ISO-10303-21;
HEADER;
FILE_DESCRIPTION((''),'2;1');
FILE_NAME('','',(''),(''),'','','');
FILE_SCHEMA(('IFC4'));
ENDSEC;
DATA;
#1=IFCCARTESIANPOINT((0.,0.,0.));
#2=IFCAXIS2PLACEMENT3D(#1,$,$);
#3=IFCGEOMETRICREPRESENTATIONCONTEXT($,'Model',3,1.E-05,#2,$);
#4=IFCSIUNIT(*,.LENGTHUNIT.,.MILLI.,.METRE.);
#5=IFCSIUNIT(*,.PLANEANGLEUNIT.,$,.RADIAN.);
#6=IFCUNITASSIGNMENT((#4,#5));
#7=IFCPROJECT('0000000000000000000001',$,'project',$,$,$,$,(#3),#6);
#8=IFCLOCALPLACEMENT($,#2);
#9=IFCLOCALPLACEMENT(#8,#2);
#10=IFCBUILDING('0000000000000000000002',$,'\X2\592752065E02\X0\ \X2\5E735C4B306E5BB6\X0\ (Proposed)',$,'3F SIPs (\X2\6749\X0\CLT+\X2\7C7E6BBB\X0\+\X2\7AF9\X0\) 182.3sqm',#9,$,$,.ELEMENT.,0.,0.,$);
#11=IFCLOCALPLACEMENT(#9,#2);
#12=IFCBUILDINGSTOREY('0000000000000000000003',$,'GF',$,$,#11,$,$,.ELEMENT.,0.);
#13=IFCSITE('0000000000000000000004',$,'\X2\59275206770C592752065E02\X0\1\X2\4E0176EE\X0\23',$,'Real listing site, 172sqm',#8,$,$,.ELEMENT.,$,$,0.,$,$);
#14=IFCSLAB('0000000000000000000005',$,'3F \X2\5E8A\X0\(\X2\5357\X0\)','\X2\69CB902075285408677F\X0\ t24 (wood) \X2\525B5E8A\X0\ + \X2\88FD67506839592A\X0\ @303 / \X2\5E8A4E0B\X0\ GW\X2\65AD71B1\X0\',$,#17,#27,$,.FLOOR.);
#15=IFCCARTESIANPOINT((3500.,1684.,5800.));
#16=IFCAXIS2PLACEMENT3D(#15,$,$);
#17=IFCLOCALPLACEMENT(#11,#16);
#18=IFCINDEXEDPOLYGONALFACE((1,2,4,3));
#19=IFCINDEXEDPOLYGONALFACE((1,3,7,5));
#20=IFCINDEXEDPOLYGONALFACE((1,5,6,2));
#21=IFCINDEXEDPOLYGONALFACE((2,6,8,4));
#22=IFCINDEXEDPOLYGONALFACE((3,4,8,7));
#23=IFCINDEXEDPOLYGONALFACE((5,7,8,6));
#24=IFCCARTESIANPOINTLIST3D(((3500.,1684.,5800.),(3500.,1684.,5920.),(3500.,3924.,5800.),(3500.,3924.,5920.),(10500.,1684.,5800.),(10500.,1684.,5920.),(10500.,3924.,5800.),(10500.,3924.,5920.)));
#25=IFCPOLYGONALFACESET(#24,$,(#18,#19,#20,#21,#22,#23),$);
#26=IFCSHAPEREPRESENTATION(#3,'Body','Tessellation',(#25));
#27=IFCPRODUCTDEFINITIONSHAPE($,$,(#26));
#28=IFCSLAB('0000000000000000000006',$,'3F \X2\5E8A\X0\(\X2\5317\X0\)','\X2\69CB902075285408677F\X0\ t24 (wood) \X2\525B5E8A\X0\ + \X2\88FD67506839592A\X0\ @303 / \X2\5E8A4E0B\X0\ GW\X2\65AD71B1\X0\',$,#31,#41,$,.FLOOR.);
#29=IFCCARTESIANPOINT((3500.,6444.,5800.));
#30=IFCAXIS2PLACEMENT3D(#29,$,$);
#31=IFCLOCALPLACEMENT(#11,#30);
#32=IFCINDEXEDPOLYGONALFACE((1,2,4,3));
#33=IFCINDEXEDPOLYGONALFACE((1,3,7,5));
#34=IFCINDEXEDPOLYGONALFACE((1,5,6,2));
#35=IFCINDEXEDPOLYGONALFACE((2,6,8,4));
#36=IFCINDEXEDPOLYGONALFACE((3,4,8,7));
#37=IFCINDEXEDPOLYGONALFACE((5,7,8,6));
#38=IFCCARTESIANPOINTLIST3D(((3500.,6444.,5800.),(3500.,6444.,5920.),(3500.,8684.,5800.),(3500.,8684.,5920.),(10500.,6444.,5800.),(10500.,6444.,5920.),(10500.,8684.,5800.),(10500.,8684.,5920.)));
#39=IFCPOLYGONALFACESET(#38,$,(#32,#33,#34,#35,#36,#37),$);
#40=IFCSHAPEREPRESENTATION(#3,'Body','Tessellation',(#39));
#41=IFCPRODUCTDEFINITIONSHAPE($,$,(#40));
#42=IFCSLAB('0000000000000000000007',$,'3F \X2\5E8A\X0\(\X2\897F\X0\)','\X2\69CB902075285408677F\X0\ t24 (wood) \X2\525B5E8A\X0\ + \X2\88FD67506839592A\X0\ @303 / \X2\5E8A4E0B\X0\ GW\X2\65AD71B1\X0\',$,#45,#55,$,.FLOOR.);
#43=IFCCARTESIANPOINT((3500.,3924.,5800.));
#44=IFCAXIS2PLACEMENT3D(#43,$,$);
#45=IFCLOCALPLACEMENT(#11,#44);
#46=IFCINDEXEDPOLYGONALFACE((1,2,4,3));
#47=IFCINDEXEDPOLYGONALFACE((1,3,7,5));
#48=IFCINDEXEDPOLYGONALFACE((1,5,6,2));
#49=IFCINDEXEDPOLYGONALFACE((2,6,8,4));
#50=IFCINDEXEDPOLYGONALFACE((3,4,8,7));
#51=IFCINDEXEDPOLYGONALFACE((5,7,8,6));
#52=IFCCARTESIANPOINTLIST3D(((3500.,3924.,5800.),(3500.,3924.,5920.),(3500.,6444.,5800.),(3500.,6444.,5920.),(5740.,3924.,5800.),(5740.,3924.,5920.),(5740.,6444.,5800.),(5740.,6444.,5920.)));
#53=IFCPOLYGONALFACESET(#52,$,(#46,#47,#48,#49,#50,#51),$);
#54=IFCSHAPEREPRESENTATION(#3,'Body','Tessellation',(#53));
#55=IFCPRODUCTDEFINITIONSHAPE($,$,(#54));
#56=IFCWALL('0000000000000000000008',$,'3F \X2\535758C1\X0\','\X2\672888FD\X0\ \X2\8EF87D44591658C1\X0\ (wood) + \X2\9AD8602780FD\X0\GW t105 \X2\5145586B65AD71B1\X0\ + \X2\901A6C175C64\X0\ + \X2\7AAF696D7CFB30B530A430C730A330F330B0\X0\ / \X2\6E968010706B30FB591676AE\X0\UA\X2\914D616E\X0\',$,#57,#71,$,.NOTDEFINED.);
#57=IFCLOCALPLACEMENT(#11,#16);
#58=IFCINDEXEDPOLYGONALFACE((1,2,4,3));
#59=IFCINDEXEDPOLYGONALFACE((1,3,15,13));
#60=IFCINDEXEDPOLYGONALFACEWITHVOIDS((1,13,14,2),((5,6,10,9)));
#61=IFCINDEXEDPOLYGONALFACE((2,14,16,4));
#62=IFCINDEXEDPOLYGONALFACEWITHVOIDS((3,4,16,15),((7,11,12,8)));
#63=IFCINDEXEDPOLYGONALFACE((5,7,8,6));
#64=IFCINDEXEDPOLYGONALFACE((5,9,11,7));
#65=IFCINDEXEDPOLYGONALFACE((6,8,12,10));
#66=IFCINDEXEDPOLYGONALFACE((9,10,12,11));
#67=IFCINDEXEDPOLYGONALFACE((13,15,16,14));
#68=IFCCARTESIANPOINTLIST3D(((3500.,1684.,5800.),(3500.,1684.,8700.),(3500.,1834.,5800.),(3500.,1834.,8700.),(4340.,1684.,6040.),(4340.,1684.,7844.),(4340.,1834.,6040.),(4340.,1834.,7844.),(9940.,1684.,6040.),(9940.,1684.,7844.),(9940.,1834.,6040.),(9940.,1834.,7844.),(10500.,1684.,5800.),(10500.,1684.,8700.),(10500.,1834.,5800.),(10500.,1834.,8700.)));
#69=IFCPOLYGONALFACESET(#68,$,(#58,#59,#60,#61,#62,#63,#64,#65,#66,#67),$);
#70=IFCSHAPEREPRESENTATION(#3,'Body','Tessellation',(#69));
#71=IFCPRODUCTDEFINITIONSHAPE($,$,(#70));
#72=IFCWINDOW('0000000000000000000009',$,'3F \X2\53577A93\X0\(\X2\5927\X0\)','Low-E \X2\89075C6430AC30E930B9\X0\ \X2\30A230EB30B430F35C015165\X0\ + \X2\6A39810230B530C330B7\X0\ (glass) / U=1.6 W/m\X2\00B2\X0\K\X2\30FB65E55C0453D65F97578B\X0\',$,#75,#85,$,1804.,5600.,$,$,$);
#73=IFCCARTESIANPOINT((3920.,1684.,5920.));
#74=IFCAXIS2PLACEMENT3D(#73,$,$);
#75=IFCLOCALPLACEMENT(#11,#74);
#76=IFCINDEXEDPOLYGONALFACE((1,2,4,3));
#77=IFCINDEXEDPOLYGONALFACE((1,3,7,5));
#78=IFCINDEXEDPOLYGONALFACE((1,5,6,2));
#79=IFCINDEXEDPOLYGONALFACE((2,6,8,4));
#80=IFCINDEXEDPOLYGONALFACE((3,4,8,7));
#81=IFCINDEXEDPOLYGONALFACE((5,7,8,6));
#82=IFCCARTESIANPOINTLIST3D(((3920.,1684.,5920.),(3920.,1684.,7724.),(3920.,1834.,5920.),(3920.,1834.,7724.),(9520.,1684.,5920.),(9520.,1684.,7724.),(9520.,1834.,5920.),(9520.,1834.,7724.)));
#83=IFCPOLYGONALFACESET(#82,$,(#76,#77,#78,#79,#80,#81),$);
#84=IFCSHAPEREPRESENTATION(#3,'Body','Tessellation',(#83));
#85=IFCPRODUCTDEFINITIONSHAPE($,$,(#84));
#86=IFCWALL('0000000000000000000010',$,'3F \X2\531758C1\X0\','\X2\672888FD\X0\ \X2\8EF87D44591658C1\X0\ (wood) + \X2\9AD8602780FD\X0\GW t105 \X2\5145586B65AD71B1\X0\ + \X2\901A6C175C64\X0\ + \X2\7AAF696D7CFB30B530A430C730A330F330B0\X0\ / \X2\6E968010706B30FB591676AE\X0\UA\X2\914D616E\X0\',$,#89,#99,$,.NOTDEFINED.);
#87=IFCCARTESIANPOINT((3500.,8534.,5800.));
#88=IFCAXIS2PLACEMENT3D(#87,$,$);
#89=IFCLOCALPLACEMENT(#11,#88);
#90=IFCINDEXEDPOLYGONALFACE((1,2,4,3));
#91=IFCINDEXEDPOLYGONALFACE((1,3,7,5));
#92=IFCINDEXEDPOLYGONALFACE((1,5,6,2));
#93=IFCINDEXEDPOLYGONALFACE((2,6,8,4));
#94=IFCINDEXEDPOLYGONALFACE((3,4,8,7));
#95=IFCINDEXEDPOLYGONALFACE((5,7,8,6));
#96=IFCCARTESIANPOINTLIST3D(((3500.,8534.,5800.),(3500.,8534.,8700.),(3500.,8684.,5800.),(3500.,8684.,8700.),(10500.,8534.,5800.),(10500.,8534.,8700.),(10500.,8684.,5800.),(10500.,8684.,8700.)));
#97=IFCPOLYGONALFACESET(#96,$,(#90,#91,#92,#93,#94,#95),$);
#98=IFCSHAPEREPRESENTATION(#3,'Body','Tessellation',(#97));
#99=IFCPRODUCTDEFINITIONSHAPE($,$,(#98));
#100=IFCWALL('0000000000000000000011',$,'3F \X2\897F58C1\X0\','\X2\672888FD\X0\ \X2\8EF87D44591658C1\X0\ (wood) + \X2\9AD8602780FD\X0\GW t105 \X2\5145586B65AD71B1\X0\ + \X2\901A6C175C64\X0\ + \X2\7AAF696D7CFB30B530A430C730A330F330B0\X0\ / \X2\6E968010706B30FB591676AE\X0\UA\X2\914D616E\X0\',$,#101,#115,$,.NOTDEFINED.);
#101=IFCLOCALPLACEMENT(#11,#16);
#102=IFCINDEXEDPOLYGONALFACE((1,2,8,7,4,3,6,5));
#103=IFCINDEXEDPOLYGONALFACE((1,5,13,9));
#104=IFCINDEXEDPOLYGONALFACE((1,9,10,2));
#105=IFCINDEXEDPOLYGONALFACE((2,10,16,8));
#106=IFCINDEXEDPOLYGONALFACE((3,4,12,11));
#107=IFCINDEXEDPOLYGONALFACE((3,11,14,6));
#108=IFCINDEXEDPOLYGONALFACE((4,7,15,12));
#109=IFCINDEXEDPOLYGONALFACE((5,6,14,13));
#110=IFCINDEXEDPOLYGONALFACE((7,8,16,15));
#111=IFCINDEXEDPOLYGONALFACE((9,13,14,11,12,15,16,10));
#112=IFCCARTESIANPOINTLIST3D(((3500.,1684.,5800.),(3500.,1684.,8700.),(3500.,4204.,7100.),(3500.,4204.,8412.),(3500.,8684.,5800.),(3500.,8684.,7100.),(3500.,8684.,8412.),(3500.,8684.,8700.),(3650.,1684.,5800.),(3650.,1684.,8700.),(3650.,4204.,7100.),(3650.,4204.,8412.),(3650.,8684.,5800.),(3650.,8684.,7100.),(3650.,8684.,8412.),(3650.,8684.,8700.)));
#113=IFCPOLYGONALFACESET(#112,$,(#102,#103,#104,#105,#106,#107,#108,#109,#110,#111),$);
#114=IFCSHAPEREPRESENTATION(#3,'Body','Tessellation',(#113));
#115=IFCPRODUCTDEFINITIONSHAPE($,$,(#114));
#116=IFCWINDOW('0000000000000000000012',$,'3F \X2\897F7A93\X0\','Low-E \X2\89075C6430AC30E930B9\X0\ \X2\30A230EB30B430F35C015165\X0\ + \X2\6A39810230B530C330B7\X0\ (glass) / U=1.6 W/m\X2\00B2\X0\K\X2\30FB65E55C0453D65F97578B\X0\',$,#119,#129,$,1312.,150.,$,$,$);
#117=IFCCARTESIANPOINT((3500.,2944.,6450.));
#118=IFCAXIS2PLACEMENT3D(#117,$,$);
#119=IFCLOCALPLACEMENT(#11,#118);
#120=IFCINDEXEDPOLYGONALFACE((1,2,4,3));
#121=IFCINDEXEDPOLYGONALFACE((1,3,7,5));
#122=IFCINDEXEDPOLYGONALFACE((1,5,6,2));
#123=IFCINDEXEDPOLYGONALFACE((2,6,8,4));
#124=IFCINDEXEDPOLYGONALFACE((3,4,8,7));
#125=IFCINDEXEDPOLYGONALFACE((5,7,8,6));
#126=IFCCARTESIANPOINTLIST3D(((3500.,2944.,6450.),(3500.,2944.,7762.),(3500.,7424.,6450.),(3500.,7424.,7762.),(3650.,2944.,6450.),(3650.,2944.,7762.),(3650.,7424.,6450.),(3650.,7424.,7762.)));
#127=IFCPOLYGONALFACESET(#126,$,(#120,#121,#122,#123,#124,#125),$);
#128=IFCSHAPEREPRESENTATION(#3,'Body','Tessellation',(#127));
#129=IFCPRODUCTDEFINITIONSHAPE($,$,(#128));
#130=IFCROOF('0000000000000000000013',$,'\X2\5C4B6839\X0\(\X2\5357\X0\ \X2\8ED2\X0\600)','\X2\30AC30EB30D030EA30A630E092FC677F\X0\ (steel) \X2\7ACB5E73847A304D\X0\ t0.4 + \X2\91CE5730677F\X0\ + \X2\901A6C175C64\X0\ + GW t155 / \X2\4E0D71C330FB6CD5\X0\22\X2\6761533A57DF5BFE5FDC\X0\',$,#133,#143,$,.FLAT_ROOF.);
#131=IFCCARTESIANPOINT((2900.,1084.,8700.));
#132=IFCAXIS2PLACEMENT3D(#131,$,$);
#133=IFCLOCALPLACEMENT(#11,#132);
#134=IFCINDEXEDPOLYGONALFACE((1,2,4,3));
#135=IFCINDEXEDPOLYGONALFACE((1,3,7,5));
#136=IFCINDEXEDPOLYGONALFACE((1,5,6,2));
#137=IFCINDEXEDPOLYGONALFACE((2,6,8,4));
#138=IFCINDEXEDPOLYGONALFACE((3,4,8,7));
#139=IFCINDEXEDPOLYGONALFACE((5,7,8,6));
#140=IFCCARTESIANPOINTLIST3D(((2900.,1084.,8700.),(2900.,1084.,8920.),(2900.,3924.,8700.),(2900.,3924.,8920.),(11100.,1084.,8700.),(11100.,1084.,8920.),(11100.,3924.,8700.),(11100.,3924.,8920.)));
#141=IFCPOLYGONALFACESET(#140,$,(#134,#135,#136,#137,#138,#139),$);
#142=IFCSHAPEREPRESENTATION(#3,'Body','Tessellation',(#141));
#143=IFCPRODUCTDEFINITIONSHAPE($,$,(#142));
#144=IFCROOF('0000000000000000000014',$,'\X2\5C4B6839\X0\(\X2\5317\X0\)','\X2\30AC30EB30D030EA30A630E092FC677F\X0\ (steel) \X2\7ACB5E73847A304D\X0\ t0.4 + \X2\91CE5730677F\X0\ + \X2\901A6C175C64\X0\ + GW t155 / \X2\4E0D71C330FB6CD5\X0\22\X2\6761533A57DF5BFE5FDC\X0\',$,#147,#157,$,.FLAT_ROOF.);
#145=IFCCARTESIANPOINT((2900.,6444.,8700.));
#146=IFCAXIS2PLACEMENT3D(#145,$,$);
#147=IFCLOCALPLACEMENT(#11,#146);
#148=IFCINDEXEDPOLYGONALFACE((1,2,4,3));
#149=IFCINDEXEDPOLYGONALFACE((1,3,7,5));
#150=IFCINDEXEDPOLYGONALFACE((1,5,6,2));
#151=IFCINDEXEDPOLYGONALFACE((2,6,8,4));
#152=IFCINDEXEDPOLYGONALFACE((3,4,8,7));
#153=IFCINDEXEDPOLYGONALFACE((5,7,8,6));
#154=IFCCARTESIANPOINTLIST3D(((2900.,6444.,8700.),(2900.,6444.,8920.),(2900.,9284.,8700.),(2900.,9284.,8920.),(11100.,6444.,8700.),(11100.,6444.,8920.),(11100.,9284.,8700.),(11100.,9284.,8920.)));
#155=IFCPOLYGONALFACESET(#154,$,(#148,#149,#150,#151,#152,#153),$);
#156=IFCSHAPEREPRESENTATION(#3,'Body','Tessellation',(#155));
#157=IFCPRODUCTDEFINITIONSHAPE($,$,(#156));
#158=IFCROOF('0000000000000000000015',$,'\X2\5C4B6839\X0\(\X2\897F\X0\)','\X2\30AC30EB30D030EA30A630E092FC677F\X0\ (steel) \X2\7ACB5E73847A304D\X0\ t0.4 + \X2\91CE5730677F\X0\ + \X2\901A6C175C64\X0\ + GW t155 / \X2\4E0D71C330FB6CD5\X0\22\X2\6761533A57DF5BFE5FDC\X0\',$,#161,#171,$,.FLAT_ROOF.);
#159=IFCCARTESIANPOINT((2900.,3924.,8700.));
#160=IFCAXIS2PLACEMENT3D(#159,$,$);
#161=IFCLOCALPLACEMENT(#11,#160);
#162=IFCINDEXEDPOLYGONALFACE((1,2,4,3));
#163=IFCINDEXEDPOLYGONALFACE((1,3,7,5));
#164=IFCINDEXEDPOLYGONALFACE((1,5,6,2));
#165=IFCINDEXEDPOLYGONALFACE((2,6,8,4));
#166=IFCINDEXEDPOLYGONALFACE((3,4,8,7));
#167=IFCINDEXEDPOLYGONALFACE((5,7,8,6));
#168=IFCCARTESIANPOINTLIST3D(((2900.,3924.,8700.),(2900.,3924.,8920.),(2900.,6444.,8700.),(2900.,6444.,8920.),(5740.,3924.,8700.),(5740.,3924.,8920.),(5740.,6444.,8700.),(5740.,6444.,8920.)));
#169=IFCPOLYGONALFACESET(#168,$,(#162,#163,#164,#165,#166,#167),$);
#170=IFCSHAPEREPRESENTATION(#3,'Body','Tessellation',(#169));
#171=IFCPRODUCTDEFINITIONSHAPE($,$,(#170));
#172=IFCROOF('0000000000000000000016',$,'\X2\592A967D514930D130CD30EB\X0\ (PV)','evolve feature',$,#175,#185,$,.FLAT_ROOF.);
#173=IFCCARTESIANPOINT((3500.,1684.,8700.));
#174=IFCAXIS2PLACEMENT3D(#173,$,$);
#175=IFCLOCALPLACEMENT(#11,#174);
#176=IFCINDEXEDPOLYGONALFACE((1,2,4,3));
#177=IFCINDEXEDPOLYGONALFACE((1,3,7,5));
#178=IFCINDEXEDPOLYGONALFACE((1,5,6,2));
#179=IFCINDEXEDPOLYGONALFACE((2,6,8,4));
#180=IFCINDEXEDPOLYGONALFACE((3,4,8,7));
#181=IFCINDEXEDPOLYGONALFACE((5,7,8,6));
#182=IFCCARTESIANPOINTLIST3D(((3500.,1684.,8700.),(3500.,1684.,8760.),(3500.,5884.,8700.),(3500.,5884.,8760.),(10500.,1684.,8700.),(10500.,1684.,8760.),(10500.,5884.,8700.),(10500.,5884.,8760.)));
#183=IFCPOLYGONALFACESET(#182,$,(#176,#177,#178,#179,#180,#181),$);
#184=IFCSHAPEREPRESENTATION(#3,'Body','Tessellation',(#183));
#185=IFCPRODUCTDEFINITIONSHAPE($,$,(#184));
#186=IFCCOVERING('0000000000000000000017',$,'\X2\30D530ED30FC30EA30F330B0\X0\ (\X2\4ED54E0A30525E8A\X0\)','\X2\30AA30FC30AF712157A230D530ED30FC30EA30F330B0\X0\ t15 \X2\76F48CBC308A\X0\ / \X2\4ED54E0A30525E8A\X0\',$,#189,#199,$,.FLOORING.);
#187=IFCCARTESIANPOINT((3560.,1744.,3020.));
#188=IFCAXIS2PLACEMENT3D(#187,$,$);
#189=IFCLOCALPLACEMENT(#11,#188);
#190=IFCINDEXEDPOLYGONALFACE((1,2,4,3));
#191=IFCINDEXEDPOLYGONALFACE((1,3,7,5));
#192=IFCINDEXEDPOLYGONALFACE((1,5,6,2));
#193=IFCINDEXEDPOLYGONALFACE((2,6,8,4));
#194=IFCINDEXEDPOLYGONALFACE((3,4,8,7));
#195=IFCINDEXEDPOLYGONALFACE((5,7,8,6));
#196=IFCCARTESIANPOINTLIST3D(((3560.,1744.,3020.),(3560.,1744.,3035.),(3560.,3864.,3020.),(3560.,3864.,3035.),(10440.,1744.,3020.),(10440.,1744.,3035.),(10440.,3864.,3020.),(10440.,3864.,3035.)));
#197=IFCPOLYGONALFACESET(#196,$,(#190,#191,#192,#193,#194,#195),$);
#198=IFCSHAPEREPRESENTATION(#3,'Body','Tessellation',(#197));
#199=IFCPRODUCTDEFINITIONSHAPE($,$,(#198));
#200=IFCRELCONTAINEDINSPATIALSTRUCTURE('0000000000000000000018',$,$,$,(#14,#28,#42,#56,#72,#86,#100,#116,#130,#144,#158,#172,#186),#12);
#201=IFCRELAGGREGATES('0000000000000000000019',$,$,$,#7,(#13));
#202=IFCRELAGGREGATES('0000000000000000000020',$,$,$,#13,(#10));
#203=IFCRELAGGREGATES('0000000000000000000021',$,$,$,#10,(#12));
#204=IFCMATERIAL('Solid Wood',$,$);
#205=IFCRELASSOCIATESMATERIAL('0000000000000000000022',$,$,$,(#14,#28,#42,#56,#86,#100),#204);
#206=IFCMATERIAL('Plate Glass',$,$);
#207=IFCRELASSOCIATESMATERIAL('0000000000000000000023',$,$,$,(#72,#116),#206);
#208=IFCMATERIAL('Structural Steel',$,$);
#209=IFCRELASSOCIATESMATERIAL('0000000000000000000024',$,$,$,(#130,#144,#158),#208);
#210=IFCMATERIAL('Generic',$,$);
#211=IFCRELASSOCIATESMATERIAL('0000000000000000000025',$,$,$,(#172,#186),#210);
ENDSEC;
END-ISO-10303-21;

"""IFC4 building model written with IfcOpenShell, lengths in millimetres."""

from ifc_helpers import new_model, si_unit, frame, frame_2d, origin, place, context, project, spatial, rectangle, extrude, material, element, fill, save


model = new_model("IFC4")

# Units and contexts
model_context = context("Model", 3, precision=1e-05, world=origin())
ifc_project = project(units=[si_unit("LENGTHUNIT", "METRE", prefix="MILLI"), si_unit("PLANEANGLEUNIT", "RADIAN")], contexts=[model_context])

# Site, building, storey
site_placement = place(None, origin())
site = spatial("IfcSite", under=ifc_project, at=site_placement, Name="大分県大分市1丁目23", ObjectType="Real listing site, 172sqm", CompositionType="ELEMENT", RefElevation=0.0)
building_placement = place(site_placement, origin())
building = spatial("IfcBuilding", under=site, at=building_placement, Name="大分市 平屋の家 (Proposed)", ObjectType="3F SIPs (杉CLT+籾殻+竹) 182.3sqm", CompositionType="ELEMENT", ElevationOfRefHeight=0.0, ElevationOfTerrain=0.0)
storey_placement = place(building_placement, origin())
storey = spatial("IfcBuildingStorey", under=building, at=storey_placement, Name="GF", CompositionType="ELEMENT", Elevation=0.0)

# Slabs
ifc_material_1 = material(Name="Solid Wood")
slab_1_placement = place(storey_placement, frame((3500.0, 1684.0, 5800.0)))
element("IfcSlab", 1, at=slab_1_placement, inside=storey, material=ifc_material_1, Name="3F 床(南)", Description="構造用合板 t24 (wood) 剛床 + 製材根太 @303 / 床下 GW断熱", PredefinedType="FLOOR", context=model_context, shape_type="SweptSolid", body=[
    extrude(rectangle(XDim=7000.0, YDim=2240.0, at=frame_2d((3500.0, 1120.0))), frame((3500.0, 1684.0, 5800.0)), (0.0, 0.0, 1.0), 120.0),
])
slab_2_placement = place(storey_placement, frame((3500.0, 6444.0, 5800.0)))
element("IfcSlab", 2, at=slab_2_placement, inside=storey, material=ifc_material_1, Name="3F 床(北)", Description="構造用合板 t24 (wood) 剛床 + 製材根太 @303 / 床下 GW断熱", PredefinedType="FLOOR", context=model_context, shape_type="SweptSolid", body=[
    extrude(rectangle(XDim=7000.0, YDim=2240.0, at=frame_2d((3500.0, 1120.0))), frame((3500.0, 6444.0, 5800.0)), (0.0, 0.0, 1.0), 120.0),
])
slab_3_placement = place(storey_placement, frame((3500.0, 3924.0, 5800.0)))
element("IfcSlab", 3, at=slab_3_placement, inside=storey, material=ifc_material_1, Name="3F 床(西)", Description="構造用合板 t24 (wood) 剛床 + 製材根太 @303 / 床下 GW断熱", PredefinedType="FLOOR", context=model_context, shape_type="SweptSolid", body=[
    extrude(rectangle(XDim=2240.0, YDim=2520.0, at=frame_2d((1120.0, 1260.0))), frame((3500.0, 3924.0, 5800.0)), (0.0, 0.0, 1.0), 120.0),
])

# Wall, opening, window
wall_1_placement = place(storey_placement, frame((3500.0, 1684.0, 5800.0)))
wall_1 = element("IfcWall", 4, at=wall_1_placement, inside=storey, material=ifc_material_1, Name="3F 南壁", Description="木製 軸組外壁 (wood) + 高性能GW t105 充填断熱 + 通気層 + 窯業系サイディング / 準耐火・外皮UA配慮", PredefinedType="NOTDEFINED", context=model_context, shape_type="SweptSolid", body=[
    extrude(rectangle(XDim=7000.0, YDim=150.0, at=frame_2d((3500.0, 75.0))), frame((3500.0, 1684.0, 5800.0)), (0.0, 0.0, 1.0), 2900.0),
])
opening_1_placement = place(storey_placement, frame((3920.0, 1684.0, 5920.0)))
opening_1 = element("IfcOpeningElement", 5, at=opening_1_placement, cuts=wall_1, PredefinedType="NOTDEFINED", context=model_context, shape_type="SweptSolid", body=[
    extrude(rectangle(XDim=5600.0, YDim=150.0, at=frame_2d((2800.0, 75.0))), frame((3920.0, 1684.0, 5920.0)), (0.0, 0.0, 1.0), 1804.0),
])
ifc_material_2 = material(Name="Plate Glass")
window_1_placement = place(storey_placement, frame((3920.0, 1684.0, 5920.0)))
window_1 = element("IfcWindow", 6, at=window_1_placement, inside=storey, material=ifc_material_2, Name="3F 南窓(大)", Description="Low-E 複層ガラス アルゴン封入 + 樹脂サッシ (glass) / U=1.6 W/m²K・日射取得型", OverallHeight=1804.0, OverallWidth=5600.0, context=model_context, shape_type="SweptSolid", body=[
    extrude(rectangle(XDim=5600.0, YDim=150.0, at=frame_2d((2800.0, 75.0))), frame((3920.0, 1684.0, 5920.0)), (0.0, 0.0, 1.0), 1804.0),
])
fill(opening_1, window_1)

# Wall
wall_2_placement = place(storey_placement, frame((3500.0, 8534.0, 5800.0)))
element("IfcWall", 7, at=wall_2_placement, inside=storey, material=ifc_material_1, Name="3F 北壁", Description="木製 軸組外壁 (wood) + 高性能GW t105 充填断熱 + 通気層 + 窯業系サイディング / 準耐火・外皮UA配慮", PredefinedType="NOTDEFINED", context=model_context, shape_type="SweptSolid", body=[
    extrude(rectangle(XDim=7000.0, YDim=150.0, at=frame_2d((3500.0, 75.0))), frame((3500.0, 8534.0, 5800.0)), (0.0, 0.0, 1.0), 2900.0),
])

# Wall, opening, window
wall_3_placement = place(storey_placement, frame((3500.0, 1684.0, 5800.0)))
wall_3 = element("IfcWall", 8, at=wall_3_placement, inside=storey, material=ifc_material_1, Name="3F 西壁", Description="木製 軸組外壁 (wood) + 高性能GW t105 充填断熱 + 通気層 + 窯業系サイディング / 準耐火・外皮UA配慮", PredefinedType="NOTDEFINED", context=model_context, shape_type="SweptSolid", body=[
    extrude(rectangle(XDim=150.0, YDim=7000.0, at=frame_2d((75.0, 3500.0))), frame((3500.0, 1684.0, 5800.0)), (0.0, 0.0, 1.0), 2900.0),
])
opening_2_placement = place(storey_placement, frame((3500.0, 2944.0, 6450.0)))
opening_2 = element("IfcOpeningElement", 9, at=opening_2_placement, cuts=wall_3, PredefinedType="NOTDEFINED", context=model_context, shape_type="SweptSolid", body=[
    extrude(rectangle(XDim=150.0, YDim=4480.0, at=frame_2d((75.0, 2240.0))), frame((3500.0, 2944.0, 6450.0)), (0.0, 0.0, 1.0), 1312.0),
])
window_2_placement = place(storey_placement, frame((3500.0, 2944.0, 6450.0)))
window_2 = element("IfcWindow", 10, at=window_2_placement, inside=storey, material=ifc_material_2, Name="3F 西窓", Description="Low-E 複層ガラス アルゴン封入 + 樹脂サッシ (glass) / U=1.6 W/m²K・日射取得型", OverallHeight=1312.0, OverallWidth=150.0, context=model_context, shape_type="SweptSolid", body=[
    extrude(rectangle(XDim=150.0, YDim=4480.0, at=frame_2d((75.0, 2240.0))), frame((3500.0, 2944.0, 6450.0)), (0.0, 0.0, 1.0), 1312.0),
])
fill(opening_2, window_2)

# Roofs
ifc_material_3 = material(Name="Structural Steel")
roof_1_placement = place(storey_placement, frame((2900.0, 1084.0, 8700.0)))
element("IfcRoof", 11, at=roof_1_placement, inside=storey, material=ifc_material_3, Name="屋根(南 軒600)", Description="ガルバリウム鋼板 (steel) 立平葺き t0.4 + 野地板 + 通気層 + GW t155 / 不燃・法22条区域対応", PredefinedType="FLAT_ROOF", context=model_context, shape_type="SweptSolid", body=[
    extrude(rectangle(XDim=8200.0, YDim=2840.0, at=frame_2d((4100.0, 1420.0))), frame((2900.0, 1084.0, 8700.0)), (0.0, 0.0, 1.0), 220.0),
])
roof_2_placement = place(storey_placement, frame((2900.0, 6444.0, 8700.0)))
element("IfcRoof", 12, at=roof_2_placement, inside=storey, material=ifc_material_3, Name="屋根(北)", Description="ガルバリウム鋼板 (steel) 立平葺き t0.4 + 野地板 + 通気層 + GW t155 / 不燃・法22条区域対応", PredefinedType="FLAT_ROOF", context=model_context, shape_type="SweptSolid", body=[
    extrude(rectangle(XDim=8200.0, YDim=2840.0, at=frame_2d((4100.0, 1420.0))), frame((2900.0, 6444.0, 8700.0)), (0.0, 0.0, 1.0), 220.0),
])
roof_3_placement = place(storey_placement, frame((2900.0, 3924.0, 8700.0)))
element("IfcRoof", 13, at=roof_3_placement, inside=storey, material=ifc_material_3, Name="屋根(西)", Description="ガルバリウム鋼板 (steel) 立平葺き t0.4 + 野地板 + 通気層 + GW t155 / 不燃・法22条区域対応", PredefinedType="FLAT_ROOF", context=model_context, shape_type="SweptSolid", body=[
    extrude(rectangle(XDim=2840.0, YDim=2520.0, at=frame_2d((1420.0, 1260.0))), frame((2900.0, 3924.0, 8700.0)), (0.0, 0.0, 1.0), 220.0),
])
ifc_material_4 = material(Name="Generic")
roof_4_placement = place(storey_placement, frame((3500.0, 1684.0, 8700.0)))
element("IfcRoof", 14, at=roof_4_placement, inside=storey, material=ifc_material_4, Name="太陽光パネル (PV)", Description="evolve feature", PredefinedType="FLAT_ROOF", context=model_context, shape_type="SweptSolid", body=[
    extrude(rectangle(XDim=7000.0, YDim=4200.0, at=frame_2d((3500.0, 2100.0))), frame((3500.0, 1684.0, 8700.0)), (0.0, 0.0, 1.0), 60.0),
])

# Covering
covering_1_placement = place(storey_placement, frame((3560.0, 1744.0, 3020.0)))
element("IfcCovering", 15, at=covering_1_placement, inside=storey, material=ifc_material_4, Name="フローリング (仕上げ床)", Description="オーク無垢フローリング t15 直貼り / 仕上げ床", PredefinedType="FLOORING", context=model_context, shape_type="SweptSolid", body=[
    extrude(rectangle(XDim=6880.0, YDim=2120.0, at=frame_2d((3440.0, 1060.0))), frame((3560.0, 1744.0, 3020.0)), (0.0, 0.0, 1.0), 15.0),
])

save(model, "model.ifc")
